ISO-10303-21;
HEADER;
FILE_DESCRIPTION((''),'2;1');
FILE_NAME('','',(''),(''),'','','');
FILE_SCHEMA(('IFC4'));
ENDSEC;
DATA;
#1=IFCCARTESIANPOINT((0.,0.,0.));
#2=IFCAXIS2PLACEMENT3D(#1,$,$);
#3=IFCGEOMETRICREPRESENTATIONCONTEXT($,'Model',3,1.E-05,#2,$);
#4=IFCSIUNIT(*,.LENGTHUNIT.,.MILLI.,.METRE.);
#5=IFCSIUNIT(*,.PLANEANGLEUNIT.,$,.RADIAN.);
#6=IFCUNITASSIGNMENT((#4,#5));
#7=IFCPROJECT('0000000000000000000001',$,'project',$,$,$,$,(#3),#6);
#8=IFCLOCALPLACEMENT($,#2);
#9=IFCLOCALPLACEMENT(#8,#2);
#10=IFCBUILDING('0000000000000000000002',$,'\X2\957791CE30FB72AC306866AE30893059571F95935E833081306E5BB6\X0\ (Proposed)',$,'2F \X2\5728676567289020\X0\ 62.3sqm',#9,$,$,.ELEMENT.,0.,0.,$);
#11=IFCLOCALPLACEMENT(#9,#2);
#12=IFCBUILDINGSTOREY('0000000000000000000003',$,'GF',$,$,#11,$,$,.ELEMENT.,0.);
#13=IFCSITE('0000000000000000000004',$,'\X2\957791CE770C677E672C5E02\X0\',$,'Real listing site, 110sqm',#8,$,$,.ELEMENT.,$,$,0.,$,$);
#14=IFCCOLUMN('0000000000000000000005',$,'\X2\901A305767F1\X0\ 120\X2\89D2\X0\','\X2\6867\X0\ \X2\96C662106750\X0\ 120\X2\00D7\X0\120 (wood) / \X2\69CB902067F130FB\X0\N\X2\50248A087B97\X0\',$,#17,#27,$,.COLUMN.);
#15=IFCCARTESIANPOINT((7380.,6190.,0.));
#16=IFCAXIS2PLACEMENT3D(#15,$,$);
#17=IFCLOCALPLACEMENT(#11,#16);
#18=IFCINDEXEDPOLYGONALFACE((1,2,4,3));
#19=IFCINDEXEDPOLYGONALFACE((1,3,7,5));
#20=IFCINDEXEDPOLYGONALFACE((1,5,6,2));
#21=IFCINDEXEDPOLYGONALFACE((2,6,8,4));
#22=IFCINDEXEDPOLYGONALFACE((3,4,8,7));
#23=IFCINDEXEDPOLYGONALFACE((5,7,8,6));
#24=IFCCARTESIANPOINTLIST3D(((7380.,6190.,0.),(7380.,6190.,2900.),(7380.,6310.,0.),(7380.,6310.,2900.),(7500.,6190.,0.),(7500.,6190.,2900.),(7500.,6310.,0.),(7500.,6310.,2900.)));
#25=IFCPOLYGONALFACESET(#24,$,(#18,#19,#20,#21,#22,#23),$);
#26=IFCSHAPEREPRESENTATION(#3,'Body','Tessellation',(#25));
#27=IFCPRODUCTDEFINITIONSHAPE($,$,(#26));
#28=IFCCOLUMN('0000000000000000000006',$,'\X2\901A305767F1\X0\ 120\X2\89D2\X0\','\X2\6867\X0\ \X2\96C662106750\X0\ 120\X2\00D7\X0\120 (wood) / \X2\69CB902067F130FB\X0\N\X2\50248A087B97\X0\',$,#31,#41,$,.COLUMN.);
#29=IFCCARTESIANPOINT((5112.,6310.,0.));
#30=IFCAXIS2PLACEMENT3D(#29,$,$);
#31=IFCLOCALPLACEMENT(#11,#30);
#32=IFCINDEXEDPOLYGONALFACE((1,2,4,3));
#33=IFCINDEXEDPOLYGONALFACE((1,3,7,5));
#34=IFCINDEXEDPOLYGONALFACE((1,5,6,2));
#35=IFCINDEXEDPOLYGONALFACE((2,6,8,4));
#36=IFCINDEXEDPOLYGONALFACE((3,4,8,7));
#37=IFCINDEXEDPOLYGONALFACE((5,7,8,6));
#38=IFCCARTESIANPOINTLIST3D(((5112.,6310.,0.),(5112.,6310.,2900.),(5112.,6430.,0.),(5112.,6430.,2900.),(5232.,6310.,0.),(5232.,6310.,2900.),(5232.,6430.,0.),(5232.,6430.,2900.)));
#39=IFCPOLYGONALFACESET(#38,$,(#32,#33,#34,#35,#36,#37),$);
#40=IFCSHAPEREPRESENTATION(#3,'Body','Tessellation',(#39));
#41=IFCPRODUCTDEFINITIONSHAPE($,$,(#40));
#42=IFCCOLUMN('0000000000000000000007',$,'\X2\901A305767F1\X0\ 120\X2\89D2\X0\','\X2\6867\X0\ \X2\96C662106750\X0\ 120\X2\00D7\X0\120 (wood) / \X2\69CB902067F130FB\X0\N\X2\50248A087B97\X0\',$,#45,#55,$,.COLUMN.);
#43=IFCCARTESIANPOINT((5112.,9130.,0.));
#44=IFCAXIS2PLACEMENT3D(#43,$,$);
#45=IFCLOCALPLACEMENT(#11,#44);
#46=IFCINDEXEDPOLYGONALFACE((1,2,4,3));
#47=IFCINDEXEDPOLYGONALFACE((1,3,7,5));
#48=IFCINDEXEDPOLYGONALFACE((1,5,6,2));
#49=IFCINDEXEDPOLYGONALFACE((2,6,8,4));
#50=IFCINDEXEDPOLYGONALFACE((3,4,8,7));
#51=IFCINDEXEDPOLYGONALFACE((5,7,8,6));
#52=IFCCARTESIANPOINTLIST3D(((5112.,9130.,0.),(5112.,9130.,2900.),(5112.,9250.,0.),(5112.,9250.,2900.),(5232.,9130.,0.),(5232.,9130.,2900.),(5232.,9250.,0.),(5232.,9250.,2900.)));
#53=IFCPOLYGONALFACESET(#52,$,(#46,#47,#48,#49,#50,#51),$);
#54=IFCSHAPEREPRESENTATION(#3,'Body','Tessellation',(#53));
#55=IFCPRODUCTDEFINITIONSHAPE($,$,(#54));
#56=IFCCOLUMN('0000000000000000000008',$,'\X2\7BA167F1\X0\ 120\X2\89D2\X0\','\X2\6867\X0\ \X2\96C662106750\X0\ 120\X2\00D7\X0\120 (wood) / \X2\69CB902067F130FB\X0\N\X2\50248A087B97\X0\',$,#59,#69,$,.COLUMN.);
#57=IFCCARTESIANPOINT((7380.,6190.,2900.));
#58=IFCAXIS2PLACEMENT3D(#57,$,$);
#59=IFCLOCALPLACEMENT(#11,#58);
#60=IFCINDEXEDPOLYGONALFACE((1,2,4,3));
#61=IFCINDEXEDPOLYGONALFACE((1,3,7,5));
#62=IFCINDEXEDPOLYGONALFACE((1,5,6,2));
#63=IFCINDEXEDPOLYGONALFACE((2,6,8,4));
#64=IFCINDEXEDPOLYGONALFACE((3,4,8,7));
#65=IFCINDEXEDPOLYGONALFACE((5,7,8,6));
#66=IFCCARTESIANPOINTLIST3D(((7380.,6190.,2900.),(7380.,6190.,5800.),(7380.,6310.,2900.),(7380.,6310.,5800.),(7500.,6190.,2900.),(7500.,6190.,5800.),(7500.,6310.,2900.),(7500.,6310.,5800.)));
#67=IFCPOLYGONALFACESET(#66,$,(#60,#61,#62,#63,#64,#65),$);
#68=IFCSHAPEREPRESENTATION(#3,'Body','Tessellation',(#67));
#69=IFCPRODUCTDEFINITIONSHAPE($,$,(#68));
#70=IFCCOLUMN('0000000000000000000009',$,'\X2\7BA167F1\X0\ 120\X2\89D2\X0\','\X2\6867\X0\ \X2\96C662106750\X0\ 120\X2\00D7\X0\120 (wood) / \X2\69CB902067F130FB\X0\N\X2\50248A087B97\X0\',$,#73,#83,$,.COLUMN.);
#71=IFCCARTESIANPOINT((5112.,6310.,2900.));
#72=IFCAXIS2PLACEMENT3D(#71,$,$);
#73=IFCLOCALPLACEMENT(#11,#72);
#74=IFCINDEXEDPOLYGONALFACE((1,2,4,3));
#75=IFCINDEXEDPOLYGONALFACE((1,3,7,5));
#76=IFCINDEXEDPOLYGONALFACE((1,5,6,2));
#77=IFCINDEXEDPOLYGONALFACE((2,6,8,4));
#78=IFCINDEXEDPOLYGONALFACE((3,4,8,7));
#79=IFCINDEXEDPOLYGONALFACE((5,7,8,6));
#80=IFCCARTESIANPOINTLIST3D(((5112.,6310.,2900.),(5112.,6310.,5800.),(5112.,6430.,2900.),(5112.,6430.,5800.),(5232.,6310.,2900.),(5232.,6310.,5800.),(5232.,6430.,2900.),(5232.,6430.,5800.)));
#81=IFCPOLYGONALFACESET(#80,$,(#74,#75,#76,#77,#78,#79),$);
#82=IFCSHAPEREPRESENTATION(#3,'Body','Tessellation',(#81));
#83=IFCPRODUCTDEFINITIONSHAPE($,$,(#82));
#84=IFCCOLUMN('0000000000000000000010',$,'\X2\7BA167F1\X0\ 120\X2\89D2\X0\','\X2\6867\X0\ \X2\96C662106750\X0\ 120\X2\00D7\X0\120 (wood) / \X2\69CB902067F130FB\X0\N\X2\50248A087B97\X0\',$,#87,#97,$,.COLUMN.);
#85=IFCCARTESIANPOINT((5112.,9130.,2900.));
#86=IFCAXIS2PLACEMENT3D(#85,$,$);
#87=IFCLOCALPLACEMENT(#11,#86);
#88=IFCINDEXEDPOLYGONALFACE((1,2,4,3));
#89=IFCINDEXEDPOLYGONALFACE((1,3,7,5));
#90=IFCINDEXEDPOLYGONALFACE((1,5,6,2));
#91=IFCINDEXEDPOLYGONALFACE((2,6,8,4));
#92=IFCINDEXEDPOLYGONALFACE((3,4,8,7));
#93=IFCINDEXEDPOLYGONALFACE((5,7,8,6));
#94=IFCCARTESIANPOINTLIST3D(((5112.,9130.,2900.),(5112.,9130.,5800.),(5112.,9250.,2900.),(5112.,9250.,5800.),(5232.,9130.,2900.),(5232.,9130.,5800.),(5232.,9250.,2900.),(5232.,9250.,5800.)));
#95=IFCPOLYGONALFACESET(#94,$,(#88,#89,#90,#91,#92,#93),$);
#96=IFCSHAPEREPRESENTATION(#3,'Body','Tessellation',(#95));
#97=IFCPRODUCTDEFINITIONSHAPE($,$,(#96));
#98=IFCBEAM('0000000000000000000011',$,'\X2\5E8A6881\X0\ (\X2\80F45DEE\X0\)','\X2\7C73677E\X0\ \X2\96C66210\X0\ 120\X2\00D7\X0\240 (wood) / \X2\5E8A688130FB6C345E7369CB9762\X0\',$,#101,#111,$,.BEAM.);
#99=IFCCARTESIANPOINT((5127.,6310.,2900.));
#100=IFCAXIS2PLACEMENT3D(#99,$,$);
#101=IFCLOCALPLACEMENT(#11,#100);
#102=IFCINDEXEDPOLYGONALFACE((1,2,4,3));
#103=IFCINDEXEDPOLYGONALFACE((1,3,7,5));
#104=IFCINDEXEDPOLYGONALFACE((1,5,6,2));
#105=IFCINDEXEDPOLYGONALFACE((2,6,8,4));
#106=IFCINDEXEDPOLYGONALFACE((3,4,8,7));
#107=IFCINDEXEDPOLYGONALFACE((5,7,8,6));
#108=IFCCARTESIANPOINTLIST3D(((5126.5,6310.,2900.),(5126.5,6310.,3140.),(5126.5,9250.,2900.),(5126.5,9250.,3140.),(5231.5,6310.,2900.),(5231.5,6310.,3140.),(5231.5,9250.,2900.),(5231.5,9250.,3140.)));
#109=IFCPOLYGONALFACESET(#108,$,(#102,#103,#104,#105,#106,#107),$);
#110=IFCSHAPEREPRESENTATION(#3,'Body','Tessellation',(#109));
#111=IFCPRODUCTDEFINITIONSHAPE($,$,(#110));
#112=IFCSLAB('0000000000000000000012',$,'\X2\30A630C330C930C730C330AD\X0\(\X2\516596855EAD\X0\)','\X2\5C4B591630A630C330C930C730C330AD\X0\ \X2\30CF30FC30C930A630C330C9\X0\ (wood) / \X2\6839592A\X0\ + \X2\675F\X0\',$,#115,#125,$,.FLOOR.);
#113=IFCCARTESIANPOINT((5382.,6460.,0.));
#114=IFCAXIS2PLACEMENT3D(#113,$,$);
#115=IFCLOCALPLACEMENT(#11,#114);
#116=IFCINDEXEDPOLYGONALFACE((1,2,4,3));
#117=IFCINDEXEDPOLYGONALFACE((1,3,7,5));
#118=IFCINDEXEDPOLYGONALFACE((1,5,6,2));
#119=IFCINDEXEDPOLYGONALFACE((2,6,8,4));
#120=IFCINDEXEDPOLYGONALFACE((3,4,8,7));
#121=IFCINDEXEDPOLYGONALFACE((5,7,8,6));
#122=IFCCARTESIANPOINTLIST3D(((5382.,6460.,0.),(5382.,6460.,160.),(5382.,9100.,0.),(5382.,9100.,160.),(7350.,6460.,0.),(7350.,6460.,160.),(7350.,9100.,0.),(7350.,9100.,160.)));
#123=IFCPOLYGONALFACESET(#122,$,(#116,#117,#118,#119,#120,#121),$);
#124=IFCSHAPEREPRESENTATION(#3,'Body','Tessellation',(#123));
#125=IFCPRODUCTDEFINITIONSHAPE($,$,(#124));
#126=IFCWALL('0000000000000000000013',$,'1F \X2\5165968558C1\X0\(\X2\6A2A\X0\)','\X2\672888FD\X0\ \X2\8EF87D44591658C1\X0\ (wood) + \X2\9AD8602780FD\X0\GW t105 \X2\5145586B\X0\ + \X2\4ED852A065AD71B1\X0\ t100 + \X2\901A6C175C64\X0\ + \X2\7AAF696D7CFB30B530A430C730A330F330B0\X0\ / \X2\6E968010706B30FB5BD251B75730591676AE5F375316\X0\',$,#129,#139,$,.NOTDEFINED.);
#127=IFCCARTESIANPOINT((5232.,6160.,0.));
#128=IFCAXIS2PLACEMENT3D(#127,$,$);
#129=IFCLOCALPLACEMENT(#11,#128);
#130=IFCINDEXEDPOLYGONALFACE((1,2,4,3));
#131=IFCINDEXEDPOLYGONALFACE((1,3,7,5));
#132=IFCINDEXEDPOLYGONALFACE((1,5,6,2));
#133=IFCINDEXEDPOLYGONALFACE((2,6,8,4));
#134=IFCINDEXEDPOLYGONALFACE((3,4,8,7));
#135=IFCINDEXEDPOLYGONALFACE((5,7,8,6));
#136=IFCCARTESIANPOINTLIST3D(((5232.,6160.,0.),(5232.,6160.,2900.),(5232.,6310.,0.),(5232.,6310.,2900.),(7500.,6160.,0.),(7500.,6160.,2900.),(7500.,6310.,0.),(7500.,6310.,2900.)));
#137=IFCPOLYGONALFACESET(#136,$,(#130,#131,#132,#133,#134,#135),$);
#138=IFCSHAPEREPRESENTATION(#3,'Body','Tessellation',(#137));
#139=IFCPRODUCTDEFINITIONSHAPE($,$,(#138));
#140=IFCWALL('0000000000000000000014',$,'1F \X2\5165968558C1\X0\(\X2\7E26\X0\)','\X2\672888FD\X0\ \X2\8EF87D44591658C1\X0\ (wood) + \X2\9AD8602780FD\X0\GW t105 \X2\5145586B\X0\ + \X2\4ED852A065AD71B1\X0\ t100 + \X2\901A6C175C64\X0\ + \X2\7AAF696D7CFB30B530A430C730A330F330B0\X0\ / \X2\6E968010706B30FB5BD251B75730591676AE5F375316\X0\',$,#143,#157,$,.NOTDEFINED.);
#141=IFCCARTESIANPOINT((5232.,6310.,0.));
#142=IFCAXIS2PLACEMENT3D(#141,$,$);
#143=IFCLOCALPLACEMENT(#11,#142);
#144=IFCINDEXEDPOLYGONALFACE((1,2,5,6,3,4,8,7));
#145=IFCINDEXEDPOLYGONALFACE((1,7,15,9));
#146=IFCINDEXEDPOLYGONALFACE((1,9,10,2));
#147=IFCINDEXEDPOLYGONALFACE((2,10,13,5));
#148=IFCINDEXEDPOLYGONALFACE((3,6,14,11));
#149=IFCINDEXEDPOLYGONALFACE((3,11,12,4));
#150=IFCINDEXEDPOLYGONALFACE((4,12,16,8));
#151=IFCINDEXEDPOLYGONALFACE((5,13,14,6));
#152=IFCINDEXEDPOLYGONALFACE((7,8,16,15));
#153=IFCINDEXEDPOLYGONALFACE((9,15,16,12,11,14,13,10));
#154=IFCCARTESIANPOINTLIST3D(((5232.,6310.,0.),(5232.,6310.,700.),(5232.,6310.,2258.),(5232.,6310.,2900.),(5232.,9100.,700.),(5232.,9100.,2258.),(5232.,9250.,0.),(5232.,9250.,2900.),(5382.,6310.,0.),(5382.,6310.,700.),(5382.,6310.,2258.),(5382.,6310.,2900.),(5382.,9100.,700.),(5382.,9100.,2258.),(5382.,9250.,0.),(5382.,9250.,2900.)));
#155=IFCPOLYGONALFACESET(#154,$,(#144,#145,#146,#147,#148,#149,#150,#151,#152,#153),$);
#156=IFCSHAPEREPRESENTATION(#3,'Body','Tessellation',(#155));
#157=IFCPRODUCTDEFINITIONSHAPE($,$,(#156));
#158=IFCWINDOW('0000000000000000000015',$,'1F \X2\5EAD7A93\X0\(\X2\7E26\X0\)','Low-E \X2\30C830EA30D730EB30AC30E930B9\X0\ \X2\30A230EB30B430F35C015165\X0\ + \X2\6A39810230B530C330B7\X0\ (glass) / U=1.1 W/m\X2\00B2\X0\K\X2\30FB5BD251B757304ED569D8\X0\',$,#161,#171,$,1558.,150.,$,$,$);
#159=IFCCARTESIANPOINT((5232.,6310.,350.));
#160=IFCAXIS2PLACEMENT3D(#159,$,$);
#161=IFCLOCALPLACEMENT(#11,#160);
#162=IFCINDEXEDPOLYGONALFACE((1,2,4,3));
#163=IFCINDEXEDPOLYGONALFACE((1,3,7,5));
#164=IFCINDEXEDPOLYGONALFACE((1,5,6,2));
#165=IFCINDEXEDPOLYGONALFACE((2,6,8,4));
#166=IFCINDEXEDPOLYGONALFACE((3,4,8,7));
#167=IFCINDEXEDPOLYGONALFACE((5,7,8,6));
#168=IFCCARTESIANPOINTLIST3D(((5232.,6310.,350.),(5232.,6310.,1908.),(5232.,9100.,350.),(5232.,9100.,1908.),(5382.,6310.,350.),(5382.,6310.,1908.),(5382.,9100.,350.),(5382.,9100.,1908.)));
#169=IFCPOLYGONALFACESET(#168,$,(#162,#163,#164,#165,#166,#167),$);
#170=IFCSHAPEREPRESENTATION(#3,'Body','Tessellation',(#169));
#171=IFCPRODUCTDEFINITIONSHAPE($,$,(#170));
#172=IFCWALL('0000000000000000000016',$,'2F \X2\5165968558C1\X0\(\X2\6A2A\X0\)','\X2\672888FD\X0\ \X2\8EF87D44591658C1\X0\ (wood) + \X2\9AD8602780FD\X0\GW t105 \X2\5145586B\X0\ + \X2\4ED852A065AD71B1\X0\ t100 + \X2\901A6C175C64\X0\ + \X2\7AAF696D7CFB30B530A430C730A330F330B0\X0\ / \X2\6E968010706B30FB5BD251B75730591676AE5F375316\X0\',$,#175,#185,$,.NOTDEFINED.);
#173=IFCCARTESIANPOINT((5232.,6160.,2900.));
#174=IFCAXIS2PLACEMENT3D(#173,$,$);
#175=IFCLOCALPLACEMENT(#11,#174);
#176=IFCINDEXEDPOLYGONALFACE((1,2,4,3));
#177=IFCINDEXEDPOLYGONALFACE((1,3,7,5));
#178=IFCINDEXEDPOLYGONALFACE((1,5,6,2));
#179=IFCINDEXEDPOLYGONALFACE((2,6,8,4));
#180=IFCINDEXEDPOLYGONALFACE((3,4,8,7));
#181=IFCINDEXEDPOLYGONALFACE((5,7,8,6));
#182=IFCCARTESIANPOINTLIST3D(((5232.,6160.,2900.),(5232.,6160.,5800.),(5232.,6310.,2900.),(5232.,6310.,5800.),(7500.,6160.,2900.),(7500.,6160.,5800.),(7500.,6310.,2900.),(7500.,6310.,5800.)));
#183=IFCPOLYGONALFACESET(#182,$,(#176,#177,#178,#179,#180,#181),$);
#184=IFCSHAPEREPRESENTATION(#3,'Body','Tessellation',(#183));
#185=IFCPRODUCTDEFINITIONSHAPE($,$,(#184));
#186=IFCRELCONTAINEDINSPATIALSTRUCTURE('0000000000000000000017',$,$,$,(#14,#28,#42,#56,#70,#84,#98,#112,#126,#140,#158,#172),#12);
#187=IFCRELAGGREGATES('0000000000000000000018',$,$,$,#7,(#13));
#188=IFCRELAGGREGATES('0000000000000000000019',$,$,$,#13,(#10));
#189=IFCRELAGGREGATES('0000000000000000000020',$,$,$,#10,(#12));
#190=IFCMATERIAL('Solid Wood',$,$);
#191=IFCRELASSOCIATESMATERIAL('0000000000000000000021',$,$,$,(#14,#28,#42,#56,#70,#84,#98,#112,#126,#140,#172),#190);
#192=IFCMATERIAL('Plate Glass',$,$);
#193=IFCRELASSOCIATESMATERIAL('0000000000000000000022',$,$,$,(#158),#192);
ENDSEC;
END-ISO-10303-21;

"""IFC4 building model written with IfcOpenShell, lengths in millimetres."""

from ifc_helpers import new_model, si_unit, frame, frame_2d, origin, place, context, project, spatial, rectangle, extrude, material, element, fill, save


model = new_model("IFC4")

# Units and contexts
model_context = context("Model", 3, precision=1e-05, world=origin())
ifc_project = project(units=[si_unit("LENGTHUNIT", "METRE", prefix="MILLI"), si_unit("PLANEANGLEUNIT", "RADIAN")], contexts=[model_context])

# Site, building, storey
site_placement = place(None, origin())
site = spatial("IfcSite", under=ifc_project, at=site_placement, Name="長野県松本市", ObjectType="Real listing site, 110sqm", CompositionType="ELEMENT", RefElevation=0.0)
building_placement = place(site_placement, origin())
building = spatial("IfcBuilding", under=site, at=building_placement, Name="長野・犬と暮らす土間広めの家 (Proposed)", ObjectType="2F 在来木造 62.3sqm", CompositionType="ELEMENT", ElevationOfRefHeight=0.0, ElevationOfTerrain=0.0)
storey_placement = place(building_placement, origin())
storey = spatial("IfcBuildingStorey", under=building, at=storey_placement, Name="GF", CompositionType="ELEMENT", Elevation=0.0)

# Columns
ifc_material_1 = material(Name="Solid Wood")
column_1_placement = place(storey_placement, frame((7380.0, 6190.0, 0.0)))
element("IfcColumn", 1, at=column_1_placement, inside=storey, material=ifc_material_1, Name="通し柱 120角", Description="桧 集成材 120×120 (wood) / 構造柱・N値計算", PredefinedType="COLUMN", context=model_context, shape_type="SweptSolid", body=[
    extrude(rectangle(XDim=120.0, YDim=120.0, at=frame_2d((60.0, 60.0))), frame((7380.0, 6190.0, 0.0)), (0.0, 0.0, 1.0), 2900.0),
])
column_2_placement = place(storey_placement, frame((5112.0, 6310.0, 0.0)))
element("IfcColumn", 2, at=column_2_placement, inside=storey, material=ifc_material_1, Name="通し柱 120角", Description="桧 集成材 120×120 (wood) / 構造柱・N値計算", PredefinedType="COLUMN", context=model_context, shape_type="SweptSolid", body=[
    extrude(rectangle(XDim=120.0, YDim=120.0, at=frame_2d((60.0, 60.0))), frame((5112.0, 6310.0, 0.0)), (0.0, 0.0, 1.0), 2900.0),
])
column_3_placement = place(storey_placement, frame((5112.0, 9130.0, 0.0)))
element("IfcColumn", 3, at=column_3_placement, inside=storey, material=ifc_material_1, Name="通し柱 120角", Description="桧 集成材 120×120 (wood) / 構造柱・N値計算", PredefinedType="COLUMN", context=model_context, shape_type="SweptSolid", body=[
    extrude(rectangle(XDim=120.0, YDim=120.0, at=frame_2d((60.0, 60.0))), frame((5112.0, 9130.0, 0.0)), (0.0, 0.0, 1.0), 2900.0),
])
column_4_placement = place(storey_placement, frame((7380.0, 6190.0, 2900.0)))
element("IfcColumn", 4, at=column_4_placement, inside=storey, material=ifc_material_1, Name="管柱 120角", Description="桧 集成材 120×120 (wood) / 構造柱・N値計算", PredefinedType="COLUMN", context=model_context, shape_type="SweptSolid", body=[
    extrude(rectangle(XDim=120.0, YDim=120.0, at=frame_2d((60.0, 60.0))), frame((7380.0, 6190.0, 2900.0)), (0.0, 0.0, 1.0), 2900.0),
])
column_5_placement = place(storey_placement, frame((5112.0, 6310.0, 2900.0)))
element("IfcColumn", 5, at=column_5_placement, inside=storey, material=ifc_material_1, Name="管柱 120角", Description="桧 集成材 120×120 (wood) / 構造柱・N値計算", PredefinedType="COLUMN", context=model_context, shape_type="SweptSolid", body=[
    extrude(rectangle(XDim=120.0, YDim=120.0, at=frame_2d((60.0, 60.0))), frame((5112.0, 6310.0, 2900.0)), (0.0, 0.0, 1.0), 2900.0),
])
column_6_placement = place(storey_placement, frame((5112.0, 9130.0, 2900.0)))
element("IfcColumn", 6, at=column_6_placement, inside=storey, material=ifc_material_1, Name="管柱 120角", Description="桧 集成材 120×120 (wood) / 構造柱・N値計算", PredefinedType="COLUMN", context=model_context, shape_type="SweptSolid", body=[
    extrude(rectangle(XDim=120.0, YDim=120.0, at=frame_2d((60.0, 60.0))), frame((5112.0, 9130.0, 2900.0)), (0.0, 0.0, 1.0), 2900.0),
])

# Beam
beam_1_placement = place(storey_placement, frame((5127.0, 6310.0, 2900.0)))
element("IfcBeam", 7, at=beam_1_placement, inside=storey, material=ifc_material_1, Name="床梁 (胴差)", Description="米松 集成 120×240 (wood) / 床梁・水平構面", PredefinedType="BEAM", context=model_context, shape_type="SweptSolid", body=[
    extrude(rectangle(XDim=105.0, YDim=2940.0, at=frame_2d((52.0, 1470.0))), frame((5127.0, 6310.0, 2900.0)), (0.0, 0.0, 1.0), 240.0),
])

# Slab
slab_placement = place(storey_placement, frame((5382.0, 6460.0, 0.0)))
element("IfcSlab", 8, at=slab_placement, inside=storey, material=ifc_material_1, Name="ウッドデッキ(入隅庭)", Description="屋外ウッドデッキ ハードウッド (wood) / 根太 + 束", PredefinedType="FLOOR", context=model_context, shape_type="SweptSolid", body=[
    extrude(rectangle(XDim=1968.0, YDim=2640.0, at=frame_2d((984.0, 1320.0))), frame((5382.0, 6460.0, 0.0)), (0.0, 0.0, 1.0), 160.0),
])

# Wall
wall_1_placement = place(storey_placement, frame((5232.0, 6160.0, 0.0)))
element("IfcWall", 9, at=wall_1_placement, inside=storey, material=ifc_material_1, Name="1F 入隅壁(横)", Description="木製 軸組外壁 (wood) + 高性能GW t105 充填 + 付加断熱 t100 + 通気層 + 窯業系サイディング / 準耐火・寒冷地外皮強化", PredefinedType="NOTDEFINED", context=model_context, shape_type="SweptSolid", body=[
    extrude(rectangle(XDim=2268.0, YDim=150.0, at=frame_2d((1134.0, 75.0))), frame((5232.0, 6160.0, 0.0)), (0.0, 0.0, 1.0), 2900.0),
])

# Wall, opening, window
wall_2_placement = place(storey_placement, frame((5232.0, 6310.0, 0.0)))
wall_2 = element("IfcWall", 10, at=wall_2_placement, inside=storey, material=ifc_material_1, Name="1F 入隅壁(縦)", Description="木製 軸組外壁 (wood) + 高性能GW t105 充填 + 付加断熱 t100 + 通気層 + 窯業系サイディング / 準耐火・寒冷地外皮強化", PredefinedType="NOTDEFINED", context=model_context, shape_type="SweptSolid", body=[
    extrude(rectangle(XDim=150.0, YDim=2940.0, at=frame_2d((75.0, 1470.0))), frame((5232.0, 6310.0, 0.0)), (0.0, 0.0, 1.0), 2900.0),
])
opening_1_placement = place(storey_placement, frame((5232.0, 6310.0, 350.0)))
opening_1 = element("IfcOpeningElement", 11, at=opening_1_placement, cuts=wall_2, PredefinedType="NOTDEFINED", context=model_context, shape_type="SweptSolid", body=[
    extrude(rectangle(XDim=150.0, YDim=2790.0, at=frame_2d((75.0, 1395.0))), frame((5232.0, 6310.0, 350.0)), (0.0, 0.0, 1.0), 1558.0),
])
ifc_material_2 = material(Name="Plate Glass")
window_1_placement = place(storey_placement, frame((5232.0, 6310.0, 350.0)))
window_1 = element("IfcWindow", 12, at=window_1_placement, inside=storey, material=ifc_material_2, Name="1F 庭窓(縦)", Description="Low-E トリプルガラス アルゴン封入 + 樹脂サッシ (glass) / U=1.1 W/m²K・寒冷地仕様", OverallHeight=1558.0, OverallWidth=150.0, context=model_context, shape_type="SweptSolid", body=[
    extrude(rectangle(XDim=150.0, YDim=2790.0, at=frame_2d((75.0, 1395.0))), frame((5232.0, 6310.0, 350.0)), (0.0, 0.0, 1.0), 1558.0),
])
fill(opening_1, window_1)

# Wall
wall_3_placement = place(storey_placement, frame((5232.0, 6160.0, 2900.0)))
element("IfcWall", 13, at=wall_3_placement, inside=storey, material=ifc_material_1, Name="2F 入隅壁(横)", Description="木製 軸組外壁 (wood) + 高性能GW t105 充填 + 付加断熱 t100 + 通気層 + 窯業系サイディング / 準耐火・寒冷地外皮強化", PredefinedType="NOTDEFINED", context=model_context, shape_type="SweptSolid", body=[
    extrude(rectangle(XDim=2268.0, YDim=150.0, at=frame_2d((1134.0, 75.0))), frame((5232.0, 6160.0, 2900.0)), (0.0, 0.0, 1.0), 2900.0),
])

save(model, "model.ifc")
